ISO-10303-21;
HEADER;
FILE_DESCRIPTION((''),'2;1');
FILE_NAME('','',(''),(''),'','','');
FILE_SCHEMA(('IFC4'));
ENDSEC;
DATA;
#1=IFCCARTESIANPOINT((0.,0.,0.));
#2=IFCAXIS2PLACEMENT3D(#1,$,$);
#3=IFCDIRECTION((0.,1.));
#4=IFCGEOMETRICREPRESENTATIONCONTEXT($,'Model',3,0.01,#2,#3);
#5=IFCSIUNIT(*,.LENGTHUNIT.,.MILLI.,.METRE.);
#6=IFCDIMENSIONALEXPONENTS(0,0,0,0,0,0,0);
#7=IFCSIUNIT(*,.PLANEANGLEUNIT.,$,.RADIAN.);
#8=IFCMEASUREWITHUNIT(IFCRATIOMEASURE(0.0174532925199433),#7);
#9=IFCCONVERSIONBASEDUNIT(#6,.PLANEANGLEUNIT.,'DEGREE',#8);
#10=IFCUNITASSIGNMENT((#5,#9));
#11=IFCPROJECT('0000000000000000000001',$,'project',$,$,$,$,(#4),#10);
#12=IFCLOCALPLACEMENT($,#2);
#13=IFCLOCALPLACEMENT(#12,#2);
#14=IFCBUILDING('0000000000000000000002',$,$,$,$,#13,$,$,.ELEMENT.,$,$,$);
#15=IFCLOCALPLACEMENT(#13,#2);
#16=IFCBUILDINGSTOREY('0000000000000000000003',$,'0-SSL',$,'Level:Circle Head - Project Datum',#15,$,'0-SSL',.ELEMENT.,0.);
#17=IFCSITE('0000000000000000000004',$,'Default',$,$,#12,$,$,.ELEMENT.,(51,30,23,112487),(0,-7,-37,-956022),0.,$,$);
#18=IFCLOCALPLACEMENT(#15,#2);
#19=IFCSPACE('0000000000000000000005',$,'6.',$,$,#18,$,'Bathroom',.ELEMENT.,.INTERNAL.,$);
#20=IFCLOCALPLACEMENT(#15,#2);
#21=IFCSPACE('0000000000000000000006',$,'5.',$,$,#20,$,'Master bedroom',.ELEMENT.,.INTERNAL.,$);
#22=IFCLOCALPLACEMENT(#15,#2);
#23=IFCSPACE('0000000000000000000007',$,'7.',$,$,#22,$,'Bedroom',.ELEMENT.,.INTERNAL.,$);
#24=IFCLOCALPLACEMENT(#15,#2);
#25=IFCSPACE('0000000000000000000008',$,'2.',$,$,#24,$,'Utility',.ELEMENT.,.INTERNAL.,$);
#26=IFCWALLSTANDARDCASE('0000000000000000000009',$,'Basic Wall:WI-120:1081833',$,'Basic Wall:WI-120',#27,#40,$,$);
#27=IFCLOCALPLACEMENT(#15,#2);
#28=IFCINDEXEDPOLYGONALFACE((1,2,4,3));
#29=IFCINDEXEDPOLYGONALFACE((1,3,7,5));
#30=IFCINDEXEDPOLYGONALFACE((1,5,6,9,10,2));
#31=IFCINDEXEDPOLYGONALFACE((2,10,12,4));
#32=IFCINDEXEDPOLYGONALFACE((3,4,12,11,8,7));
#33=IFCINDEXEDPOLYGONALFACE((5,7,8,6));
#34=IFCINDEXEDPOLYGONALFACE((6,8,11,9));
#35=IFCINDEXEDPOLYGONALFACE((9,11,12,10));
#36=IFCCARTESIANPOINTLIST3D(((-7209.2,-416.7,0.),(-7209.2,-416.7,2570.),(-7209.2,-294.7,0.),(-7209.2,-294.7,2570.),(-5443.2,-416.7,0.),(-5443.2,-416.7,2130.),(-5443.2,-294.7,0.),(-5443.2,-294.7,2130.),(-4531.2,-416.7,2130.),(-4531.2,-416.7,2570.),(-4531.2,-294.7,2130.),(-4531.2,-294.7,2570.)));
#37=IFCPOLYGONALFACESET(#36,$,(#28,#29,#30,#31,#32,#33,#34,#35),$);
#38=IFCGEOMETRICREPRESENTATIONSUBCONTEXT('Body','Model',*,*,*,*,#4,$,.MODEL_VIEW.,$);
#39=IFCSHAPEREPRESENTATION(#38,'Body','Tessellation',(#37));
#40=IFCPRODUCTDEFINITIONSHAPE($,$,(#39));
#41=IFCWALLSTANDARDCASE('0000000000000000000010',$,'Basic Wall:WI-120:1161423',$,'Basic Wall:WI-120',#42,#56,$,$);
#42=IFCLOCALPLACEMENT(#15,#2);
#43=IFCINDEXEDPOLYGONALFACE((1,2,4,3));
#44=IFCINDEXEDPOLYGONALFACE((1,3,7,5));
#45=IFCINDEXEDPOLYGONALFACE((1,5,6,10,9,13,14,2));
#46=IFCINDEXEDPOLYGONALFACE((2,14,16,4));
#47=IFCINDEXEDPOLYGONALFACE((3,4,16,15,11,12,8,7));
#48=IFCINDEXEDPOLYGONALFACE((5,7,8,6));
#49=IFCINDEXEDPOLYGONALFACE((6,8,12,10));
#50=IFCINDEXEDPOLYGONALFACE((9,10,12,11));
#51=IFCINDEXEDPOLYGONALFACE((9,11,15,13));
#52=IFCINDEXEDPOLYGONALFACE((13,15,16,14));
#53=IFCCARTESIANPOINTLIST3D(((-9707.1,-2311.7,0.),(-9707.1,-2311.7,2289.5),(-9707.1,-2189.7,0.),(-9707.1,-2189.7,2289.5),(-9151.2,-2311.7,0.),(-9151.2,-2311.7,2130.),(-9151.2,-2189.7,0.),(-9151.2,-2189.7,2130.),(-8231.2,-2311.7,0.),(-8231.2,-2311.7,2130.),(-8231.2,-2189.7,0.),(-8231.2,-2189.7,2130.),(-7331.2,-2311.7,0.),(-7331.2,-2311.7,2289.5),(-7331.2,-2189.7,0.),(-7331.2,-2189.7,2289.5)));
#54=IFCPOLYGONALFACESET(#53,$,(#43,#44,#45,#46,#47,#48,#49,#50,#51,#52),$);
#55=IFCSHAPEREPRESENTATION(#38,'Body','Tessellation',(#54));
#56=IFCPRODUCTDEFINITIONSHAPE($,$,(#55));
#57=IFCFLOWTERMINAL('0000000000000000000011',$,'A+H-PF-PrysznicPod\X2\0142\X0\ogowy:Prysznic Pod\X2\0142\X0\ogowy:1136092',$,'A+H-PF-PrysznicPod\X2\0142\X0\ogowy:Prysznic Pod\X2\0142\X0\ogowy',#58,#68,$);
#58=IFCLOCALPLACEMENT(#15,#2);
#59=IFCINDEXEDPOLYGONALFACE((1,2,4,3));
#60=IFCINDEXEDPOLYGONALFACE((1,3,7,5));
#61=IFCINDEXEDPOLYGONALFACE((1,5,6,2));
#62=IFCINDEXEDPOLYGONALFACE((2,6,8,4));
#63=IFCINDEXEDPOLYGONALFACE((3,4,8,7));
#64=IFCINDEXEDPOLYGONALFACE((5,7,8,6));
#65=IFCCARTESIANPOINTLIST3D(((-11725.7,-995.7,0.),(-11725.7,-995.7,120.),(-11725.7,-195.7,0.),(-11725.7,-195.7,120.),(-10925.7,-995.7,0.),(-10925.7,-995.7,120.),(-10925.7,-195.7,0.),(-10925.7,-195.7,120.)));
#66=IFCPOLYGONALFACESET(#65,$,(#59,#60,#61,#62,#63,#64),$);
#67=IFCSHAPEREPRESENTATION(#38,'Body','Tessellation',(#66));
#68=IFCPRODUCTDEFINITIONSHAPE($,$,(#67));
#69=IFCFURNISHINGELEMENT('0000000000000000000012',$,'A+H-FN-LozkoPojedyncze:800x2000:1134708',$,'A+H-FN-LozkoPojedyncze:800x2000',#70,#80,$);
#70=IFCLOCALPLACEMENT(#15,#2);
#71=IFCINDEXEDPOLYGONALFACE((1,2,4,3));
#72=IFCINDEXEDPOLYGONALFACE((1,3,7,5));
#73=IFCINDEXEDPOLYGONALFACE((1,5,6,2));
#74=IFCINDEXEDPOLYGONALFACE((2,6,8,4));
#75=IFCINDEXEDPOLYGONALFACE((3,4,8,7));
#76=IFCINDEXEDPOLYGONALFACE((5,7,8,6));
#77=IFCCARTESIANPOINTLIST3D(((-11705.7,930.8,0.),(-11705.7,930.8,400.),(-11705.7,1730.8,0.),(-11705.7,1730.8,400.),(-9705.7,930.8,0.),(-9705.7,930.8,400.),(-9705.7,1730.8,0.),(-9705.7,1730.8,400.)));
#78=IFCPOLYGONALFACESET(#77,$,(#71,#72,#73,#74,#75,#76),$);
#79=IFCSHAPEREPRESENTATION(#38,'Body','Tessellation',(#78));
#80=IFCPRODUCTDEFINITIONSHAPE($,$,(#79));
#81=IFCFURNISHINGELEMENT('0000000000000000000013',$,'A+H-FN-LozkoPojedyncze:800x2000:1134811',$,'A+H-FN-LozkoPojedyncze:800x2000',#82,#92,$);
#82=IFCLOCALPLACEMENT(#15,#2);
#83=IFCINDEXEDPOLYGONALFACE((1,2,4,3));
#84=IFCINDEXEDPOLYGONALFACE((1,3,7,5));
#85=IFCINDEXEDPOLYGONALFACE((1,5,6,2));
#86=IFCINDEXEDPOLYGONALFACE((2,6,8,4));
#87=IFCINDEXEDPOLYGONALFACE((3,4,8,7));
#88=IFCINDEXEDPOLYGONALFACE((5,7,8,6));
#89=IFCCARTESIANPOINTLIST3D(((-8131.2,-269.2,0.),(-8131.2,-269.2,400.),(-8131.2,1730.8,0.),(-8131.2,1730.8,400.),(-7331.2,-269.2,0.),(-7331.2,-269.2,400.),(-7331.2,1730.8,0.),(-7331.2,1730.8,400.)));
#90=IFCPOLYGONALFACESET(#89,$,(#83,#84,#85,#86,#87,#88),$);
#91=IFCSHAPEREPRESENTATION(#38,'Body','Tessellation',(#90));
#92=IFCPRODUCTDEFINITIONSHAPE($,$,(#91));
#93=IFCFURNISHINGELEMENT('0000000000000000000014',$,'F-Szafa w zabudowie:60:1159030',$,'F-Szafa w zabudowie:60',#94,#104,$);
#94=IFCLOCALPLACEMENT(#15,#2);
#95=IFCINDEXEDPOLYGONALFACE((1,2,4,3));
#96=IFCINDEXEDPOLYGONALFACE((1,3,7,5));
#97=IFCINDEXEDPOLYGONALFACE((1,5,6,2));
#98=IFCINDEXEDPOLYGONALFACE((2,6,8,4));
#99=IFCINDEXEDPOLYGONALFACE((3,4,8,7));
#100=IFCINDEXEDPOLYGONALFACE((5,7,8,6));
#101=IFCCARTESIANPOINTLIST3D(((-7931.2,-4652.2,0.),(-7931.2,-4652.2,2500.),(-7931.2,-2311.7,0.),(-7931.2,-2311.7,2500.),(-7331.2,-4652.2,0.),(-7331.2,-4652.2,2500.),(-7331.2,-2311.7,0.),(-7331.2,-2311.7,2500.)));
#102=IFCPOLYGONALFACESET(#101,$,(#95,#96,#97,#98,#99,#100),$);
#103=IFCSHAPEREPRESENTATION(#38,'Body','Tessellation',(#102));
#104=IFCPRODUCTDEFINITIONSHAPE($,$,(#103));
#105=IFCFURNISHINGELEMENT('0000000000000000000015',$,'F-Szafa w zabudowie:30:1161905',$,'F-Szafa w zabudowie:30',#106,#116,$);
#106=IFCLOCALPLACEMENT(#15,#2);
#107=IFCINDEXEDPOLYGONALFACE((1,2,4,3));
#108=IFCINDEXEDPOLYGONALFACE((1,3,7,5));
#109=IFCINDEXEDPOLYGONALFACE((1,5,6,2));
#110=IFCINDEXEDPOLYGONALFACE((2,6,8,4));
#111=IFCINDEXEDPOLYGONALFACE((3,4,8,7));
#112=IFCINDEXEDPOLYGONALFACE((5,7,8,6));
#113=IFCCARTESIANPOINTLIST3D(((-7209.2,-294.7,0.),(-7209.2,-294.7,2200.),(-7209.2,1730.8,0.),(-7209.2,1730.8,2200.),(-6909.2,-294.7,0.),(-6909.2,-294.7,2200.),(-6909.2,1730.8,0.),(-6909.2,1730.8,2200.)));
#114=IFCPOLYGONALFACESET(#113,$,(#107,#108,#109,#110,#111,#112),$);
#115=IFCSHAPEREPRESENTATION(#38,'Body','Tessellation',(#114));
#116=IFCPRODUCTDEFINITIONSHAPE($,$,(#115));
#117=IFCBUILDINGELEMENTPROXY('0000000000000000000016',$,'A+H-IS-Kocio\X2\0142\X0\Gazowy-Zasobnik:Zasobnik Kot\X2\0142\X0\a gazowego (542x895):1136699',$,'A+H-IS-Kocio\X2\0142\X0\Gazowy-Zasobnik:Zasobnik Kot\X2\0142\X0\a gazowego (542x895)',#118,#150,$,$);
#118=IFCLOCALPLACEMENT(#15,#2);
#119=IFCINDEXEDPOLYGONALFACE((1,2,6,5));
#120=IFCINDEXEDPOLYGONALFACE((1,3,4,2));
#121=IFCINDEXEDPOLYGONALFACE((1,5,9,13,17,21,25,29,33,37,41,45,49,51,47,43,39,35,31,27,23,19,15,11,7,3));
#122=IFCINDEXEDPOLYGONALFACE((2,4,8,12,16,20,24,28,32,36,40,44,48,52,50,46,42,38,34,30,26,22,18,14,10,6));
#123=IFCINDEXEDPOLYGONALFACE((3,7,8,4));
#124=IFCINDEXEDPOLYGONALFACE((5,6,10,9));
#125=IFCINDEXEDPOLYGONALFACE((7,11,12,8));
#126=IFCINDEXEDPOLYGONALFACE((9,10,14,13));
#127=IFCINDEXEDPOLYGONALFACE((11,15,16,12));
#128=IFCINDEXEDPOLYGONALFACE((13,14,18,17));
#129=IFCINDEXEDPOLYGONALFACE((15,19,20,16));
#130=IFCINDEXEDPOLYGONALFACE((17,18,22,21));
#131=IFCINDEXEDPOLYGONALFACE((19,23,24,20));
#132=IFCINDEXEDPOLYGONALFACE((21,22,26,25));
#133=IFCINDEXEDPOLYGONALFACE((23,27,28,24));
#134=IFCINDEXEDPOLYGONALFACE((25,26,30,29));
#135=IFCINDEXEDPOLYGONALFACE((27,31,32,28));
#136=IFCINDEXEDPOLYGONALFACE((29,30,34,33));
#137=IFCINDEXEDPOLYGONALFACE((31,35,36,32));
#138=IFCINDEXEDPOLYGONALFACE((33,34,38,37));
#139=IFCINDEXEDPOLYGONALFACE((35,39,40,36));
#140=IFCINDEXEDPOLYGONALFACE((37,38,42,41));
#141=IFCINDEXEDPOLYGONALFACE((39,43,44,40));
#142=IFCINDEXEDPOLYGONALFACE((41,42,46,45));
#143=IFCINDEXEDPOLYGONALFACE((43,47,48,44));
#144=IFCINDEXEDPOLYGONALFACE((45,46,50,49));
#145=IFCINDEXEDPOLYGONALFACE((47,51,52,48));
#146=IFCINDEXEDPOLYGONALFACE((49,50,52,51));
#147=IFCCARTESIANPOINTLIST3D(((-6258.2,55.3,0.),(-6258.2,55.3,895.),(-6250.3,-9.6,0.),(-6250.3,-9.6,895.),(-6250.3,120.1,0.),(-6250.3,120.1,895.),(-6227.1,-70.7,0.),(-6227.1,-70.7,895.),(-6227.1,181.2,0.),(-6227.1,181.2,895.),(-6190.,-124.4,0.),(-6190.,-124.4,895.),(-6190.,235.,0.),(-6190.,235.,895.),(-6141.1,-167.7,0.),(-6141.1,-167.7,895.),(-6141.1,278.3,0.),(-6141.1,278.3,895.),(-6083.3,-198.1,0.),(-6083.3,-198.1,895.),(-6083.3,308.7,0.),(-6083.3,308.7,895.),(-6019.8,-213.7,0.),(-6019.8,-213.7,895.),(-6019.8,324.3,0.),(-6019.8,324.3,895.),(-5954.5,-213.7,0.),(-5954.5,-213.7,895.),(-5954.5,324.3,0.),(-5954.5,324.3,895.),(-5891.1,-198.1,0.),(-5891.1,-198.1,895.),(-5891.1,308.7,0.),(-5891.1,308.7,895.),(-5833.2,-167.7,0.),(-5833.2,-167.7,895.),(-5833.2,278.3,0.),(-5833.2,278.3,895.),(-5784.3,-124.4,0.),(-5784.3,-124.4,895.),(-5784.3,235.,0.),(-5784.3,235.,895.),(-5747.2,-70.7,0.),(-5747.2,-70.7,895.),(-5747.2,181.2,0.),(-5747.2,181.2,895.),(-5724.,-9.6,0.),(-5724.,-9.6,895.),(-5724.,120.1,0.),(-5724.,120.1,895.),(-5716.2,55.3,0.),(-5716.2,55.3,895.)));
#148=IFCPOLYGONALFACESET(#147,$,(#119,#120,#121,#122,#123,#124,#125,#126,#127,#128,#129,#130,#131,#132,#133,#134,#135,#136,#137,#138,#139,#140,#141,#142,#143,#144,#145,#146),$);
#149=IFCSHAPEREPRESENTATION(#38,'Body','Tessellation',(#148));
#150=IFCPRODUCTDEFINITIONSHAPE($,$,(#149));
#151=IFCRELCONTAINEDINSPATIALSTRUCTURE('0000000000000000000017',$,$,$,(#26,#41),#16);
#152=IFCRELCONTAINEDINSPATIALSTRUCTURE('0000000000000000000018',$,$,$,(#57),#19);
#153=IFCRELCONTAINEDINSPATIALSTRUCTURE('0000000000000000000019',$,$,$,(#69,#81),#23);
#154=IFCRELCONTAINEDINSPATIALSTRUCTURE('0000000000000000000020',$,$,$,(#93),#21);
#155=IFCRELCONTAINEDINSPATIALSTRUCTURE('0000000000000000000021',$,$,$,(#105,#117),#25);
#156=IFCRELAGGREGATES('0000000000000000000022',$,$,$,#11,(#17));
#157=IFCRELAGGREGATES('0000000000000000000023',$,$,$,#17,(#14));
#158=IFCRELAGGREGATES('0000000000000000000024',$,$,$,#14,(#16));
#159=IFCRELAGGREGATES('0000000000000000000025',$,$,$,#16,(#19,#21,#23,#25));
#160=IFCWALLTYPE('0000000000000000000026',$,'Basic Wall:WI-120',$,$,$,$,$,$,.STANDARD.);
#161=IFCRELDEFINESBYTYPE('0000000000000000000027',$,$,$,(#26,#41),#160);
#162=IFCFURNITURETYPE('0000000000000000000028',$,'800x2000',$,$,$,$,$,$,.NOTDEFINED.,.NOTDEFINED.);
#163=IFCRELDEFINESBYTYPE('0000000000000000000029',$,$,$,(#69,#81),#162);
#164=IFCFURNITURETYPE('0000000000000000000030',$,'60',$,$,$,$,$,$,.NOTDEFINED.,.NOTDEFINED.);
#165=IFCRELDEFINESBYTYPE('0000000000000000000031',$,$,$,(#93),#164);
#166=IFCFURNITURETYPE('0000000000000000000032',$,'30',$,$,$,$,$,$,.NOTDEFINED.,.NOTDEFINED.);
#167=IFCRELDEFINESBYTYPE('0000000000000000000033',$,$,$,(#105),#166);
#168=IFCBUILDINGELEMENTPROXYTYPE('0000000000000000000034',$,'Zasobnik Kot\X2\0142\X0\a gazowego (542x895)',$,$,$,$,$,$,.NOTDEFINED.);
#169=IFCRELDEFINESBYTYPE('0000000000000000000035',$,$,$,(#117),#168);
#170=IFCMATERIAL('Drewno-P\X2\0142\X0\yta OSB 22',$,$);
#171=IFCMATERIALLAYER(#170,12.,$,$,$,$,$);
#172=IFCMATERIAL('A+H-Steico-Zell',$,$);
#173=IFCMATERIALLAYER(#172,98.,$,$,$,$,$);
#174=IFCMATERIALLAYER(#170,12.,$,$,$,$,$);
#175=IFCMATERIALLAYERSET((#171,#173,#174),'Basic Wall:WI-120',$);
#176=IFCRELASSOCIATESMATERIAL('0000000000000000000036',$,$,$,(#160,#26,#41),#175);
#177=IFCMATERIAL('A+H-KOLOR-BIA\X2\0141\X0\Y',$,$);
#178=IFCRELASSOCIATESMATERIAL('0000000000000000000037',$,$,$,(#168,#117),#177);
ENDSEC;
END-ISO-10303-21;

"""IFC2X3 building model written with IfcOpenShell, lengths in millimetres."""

from ifc_helpers import new_model, entity, si_unit, converted_unit, direction, frame, frame_2d, origin, origin_2d_with_axis, place, context, subcontext, project, spatial, polyline, rectangle, circle, extrude, clip, bounded_halfspace, source, transform, mapped, material, layer, layer_set, layer_usage, type_object, type_shapes, element, save


model = new_model("IFC2X3")

# Units and contexts
model_context = context("Model", 3, precision=0.01, world=origin(), true_north=direction((0.0, 1.0)))
body_context = subcontext(model_context, "Body", "Model", "MODEL_VIEW")
ifc_project = project(units=[si_unit("LENGTHUNIT", "METRE", prefix="MILLI"), converted_unit("PLANEANGLEUNIT", "DEGREE", entity("IfcRatioMeasure", 0.0174532925199433), si_unit("PLANEANGLEUNIT", "RADIAN"), dimensions=[0, 0, 0, 0, 0, 0, 0])], contexts=[model_context])

# Site, building, storey
site_placement = place(None, origin())
site = spatial("IfcSite", under=ifc_project, at=site_placement, Name="Default", CompositionType="ELEMENT", RefLatitude=(51, 30, 23, 112487), RefLongitude=(0, -7, -37, -956022), RefElevation=0.0)
building_placement = place(site_placement, origin())
building = spatial("IfcBuilding", under=site, at=building_placement, CompositionType="ELEMENT")
storey_placement = place(building_placement, origin())
storey = spatial("IfcBuildingStorey", under=building, at=storey_placement, Name="0-SSL", ObjectType="Level:Circle Head - Project Datum", LongName="0-SSL", CompositionType="ELEMENT", Elevation=0.0)

# Shared definitions
ifc_material_1 = material(Name="A+H-Steico-Zell")

# Shared definitions
ifc_material_2 = material(Name="Drewno-Płyta OSB 22")

# Walls, openings
ifc_layer_1 = layer(ifc_material_2, 12.0)
ifc_layer_2 = layer(ifc_material_1, 98.0)
ifc_layer_3 = layer(ifc_material_2, 12.0)
ifc_layer_set_1 = layer_set([ifc_layer_1, ifc_layer_2, ifc_layer_3], Name="Basic Wall:WI-120")
wall_type_1 = type_object("IfcWallType", Name="Basic Wall:WI-120", PredefinedType="STANDARD", material=ifc_layer_set_1)
ifc_layer_usage_1 = layer_usage(ifc_layer_set_1, "AXIS2", "NEGATIVE", 61.0)
wall_1_placement = place(storey_placement, frame((-7209.2, -355.7, 0.0)))
wall_1 = element("IfcWallStandardCase", 1, at=wall_1_placement, inside=storey, type_object=wall_type_1, material=ifc_layer_usage_1, Name="Basic Wall:WI-120:1081833", ObjectType="Basic Wall:WI-120", context=body_context, shape_type="SweptSolid", body=[
    extrude(rectangle(XDim=2678.0, YDim=122.0, at=frame_2d((1339.0, 0.0), x_axis=(-1.0, 0.0))), origin(), (0.0, 0.0, 1.0), 2570.0),
])
opening_1_placement = place(wall_1_placement, frame((1766.0, -61.0, 0.0)))
element("IfcOpeningElement", 2, at=opening_1_placement, cuts=wall_1, ObjectType="Opening", context=body_context, shape_type="SweptSolid", body=[
    extrude(rectangle(XDim=2130.0, YDim=920.0, at=frame_2d((1065.0, 460.0), x_axis=(1.0, 0.0))), frame((0.0, 0.0, 0.0), z_axis=(0.0, 1.0, 0.0), x_axis=(0.0, 0.0, 1.0)), (0.0, 0.0, 1.0), 122.0),
])
ifc_layer_usage_2 = layer_usage(ifc_layer_set_1, "AXIS2", "NEGATIVE", 61.0)
wall_2_placement = place(storey_placement, frame((-9707.1, -2250.7, 0.0)))
wall_2 = element("IfcWallStandardCase", 3, at=wall_2_placement, inside=storey, type_object=wall_type_1, material=ifc_layer_usage_2, Name="Basic Wall:WI-120:1161423", ObjectType="Basic Wall:WI-120", context=body_context, shape_type="Clipping", body=[
    clip(extrude(rectangle(XDim=2375.9, YDim=122.0, at=frame_2d((1188.0, 0.0), x_axis=(-1.0, 0.0))), origin(), (0.0, 0.0, 1.0), 2289.5), bounded_halfspace(frame((0.0, 61.0, 2289.5), z_axis=(0.0, 0.0, -1.0), x_axis=(0.0, -1.0, 0.0)), True, frame((0.0, 61.0, 2289.5)), polyline([(0.0, 0.0), (0.0, -122.0), (2375.9, -122.0), (2375.9, 0.0), (520.9, 0.0), (0.0, 0.0)]))),
])
opening_2_placement = place(wall_2_placement, frame((1475.9, 61.0, 0.0)))
element("IfcOpeningElement", 4, at=opening_2_placement, cuts=wall_2, ObjectType="Opening", context=body_context, shape_type="SweptSolid", body=[
    extrude(rectangle(XDim=2130.0, YDim=920.0, at=frame_2d((1065.0, 460.0), x_axis=(1.0, 0.0))), frame((0.0, 0.0, 0.0), z_axis=(0.0, -1.0, 0.0), x_axis=(0.0, 0.0, 1.0)), (0.0, 0.0, 1.0), 122.0),
])

# Shared definitions
space_1_placement = place(storey_placement, origin())
space_1 = spatial("IfcSpace", under=storey, at=space_1_placement, Name="6.", LongName="Bathroom", CompositionType="ELEMENT", InteriorOrExteriorSpace="INTERNAL")

# Flow terminal
shared_shape_1 = source(origin(), body_context, "Body", "SweptSolid", [
    extrude(rectangle(XDim=800.0, YDim=800.0, at=origin_2d_with_axis()), frame((0.0, 400.0, 0.0), z_axis=(0.0, 0.0, 1.0), x_axis=(-1.0, 0.0, 0.0)), (0.0, 0.0, 1.0), 120.0),
])
flow_terminal_placement = place(space_1_placement, frame((-11325.7, -995.7, 0.0)))
element("IfcFlowTerminal", 5, at=flow_terminal_placement, inside=space_1, Name="A+H-PF-PrysznicPodłogowy:Prysznic Podłogowy:1136092", ObjectType="A+H-PF-PrysznicPodłogowy:Prysznic Podłogowy", context=body_context, shape_type="MappedRepresentation", body=[
    mapped(shared_shape_1, transform((0.0, 0.0, 0.0), scale=1.0)),
])

# Shared definitions
space_2_placement = place(storey_placement, origin())
space_2 = spatial("IfcSpace", under=storey, at=space_2_placement, Name="5.", LongName="Master bedroom", CompositionType="ELEMENT", InteriorOrExteriorSpace="INTERNAL")

# Shared definitions
space_3_placement = place(storey_placement, origin())
space_3 = spatial("IfcSpace", under=storey, at=space_3_placement, Name="7.", LongName="Bedroom", CompositionType="ELEMENT", InteriorOrExteriorSpace="INTERNAL")

# Furnishing elements
furniture_type_1 = type_object("IfcFurnitureType", Name="800x2000")
shared_shape_2 = source(origin(), body_context, "Body", "SweptSolid", [
    extrude(rectangle(XDim=800.0, YDim=2000.0, at=origin_2d_with_axis()), frame((0.0, 0.0, 0.0), z_axis=(0.0, 0.0, 1.0), x_axis=(-1.0, 0.0, 0.0)), (0.0, 0.0, 1.0), 400.0),
])
type_shapes(furniture_type_1, [shared_shape_2])
furnishing_1_placement = place(space_3_placement, frame((-10705.7, 1330.8, 0.0), z_axis=(0.0, 0.0, 1.0), x_axis=(0.0, 1.0, 0.0)))
element("IfcFurnishingElement", 6, at=furnishing_1_placement, inside=space_3, type_object=furniture_type_1, Name="A+H-FN-LozkoPojedyncze:800x2000:1134708", ObjectType="A+H-FN-LozkoPojedyncze:800x2000", context=body_context, shape_type="MappedRepresentation", body=[
    mapped(shared_shape_2, transform((0.0, 0.0, 0.0), scale=1.0)),
])
furnishing_2_placement = place(space_3_placement, frame((-7731.2, 730.8, 0.0)))
element("IfcFurnishingElement", 7, at=furnishing_2_placement, inside=space_3, type_object=furniture_type_1, Name="A+H-FN-LozkoPojedyncze:800x2000:1134811", ObjectType="A+H-FN-LozkoPojedyncze:800x2000", context=body_context, shape_type="MappedRepresentation", body=[
    mapped(shared_shape_2, transform((0.0, 0.0, 0.0), scale=1.0)),
])
furniture_type_2 = type_object("IfcFurnitureType", Name="60")
shared_shape_3 = source(origin(), body_context, "Body", "SweptSolid", [
    extrude(rectangle(XDim=600.0, YDim=2340.5, at=origin_2d_with_axis()), frame((0.0, 0.0, 0.0), z_axis=(0.0, 0.0, 1.0), x_axis=(-1.0, 0.0, 0.0)), (0.0, 0.0, 1.0), 2500.0),
])
type_shapes(furniture_type_2, [shared_shape_3])
furnishing_3_placement = place(space_2_placement, frame((-7631.2, -3482.0, 0.0)))
element("IfcFurnishingElement", 8, at=furnishing_3_placement, inside=space_2, type_object=furniture_type_2, Name="F-Szafa w zabudowie:60:1159030", ObjectType="F-Szafa w zabudowie:60", context=body_context, shape_type="MappedRepresentation", body=[
    mapped(shared_shape_3, transform((0.0, 0.0, 0.0), scale=1.0)),
])

# Shared definitions
space_4_placement = place(storey_placement, origin())
space_4 = spatial("IfcSpace", under=storey, at=space_4_placement, Name="2.", LongName="Utility", CompositionType="ELEMENT", InteriorOrExteriorSpace="INTERNAL")

# Furnishing element
furniture_type_3 = type_object("IfcFurnitureType", Name="30")
shared_shape_4 = source(origin(), body_context, "Body", "SweptSolid", [
    extrude(rectangle(XDim=300.0, YDim=2025.5, at=frame_2d((0.0, 0.0), x_axis=(1.0, 0.0))), frame((0.0, 0.0, 0.0), z_axis=(0.0, 0.0, 1.0), x_axis=(-1.0, 0.0, 0.0)), (0.0, 0.0, 1.0), 2200.0),
])
type_shapes(furniture_type_3, [shared_shape_4])
furnishing_4_placement = place(space_4_placement, frame((-7059.2, 718.0, 0.0)))
element("IfcFurnishingElement", 9, at=furnishing_4_placement, inside=space_4, type_object=furniture_type_3, Name="F-Szafa w zabudowie:30:1161905", ObjectType="F-Szafa w zabudowie:30", context=body_context, shape_type="MappedRepresentation", body=[
    mapped(shared_shape_4, transform((0.0, 0.0, 0.0), scale=1.0)),
])

# Building element proxy
ifc_material_3 = material(Name="A+H-KOLOR-BIAŁY")
building_element_proxy_type = type_object("IfcBuildingElementProxyType", Name="Zasobnik Kotła gazowego (542x895)", PredefinedType="NOTDEFINED", material=ifc_material_3)
shared_shape_5 = source(origin(), body_context, "Body", "SweptSolid", [
    extrude(circle(Radius=271.0, at=frame_2d((0.0, 0.0), x_axis=(1.0, 0.0))), origin(), (0.0, 0.0, 1.0), 895.0),
])
type_shapes(building_element_proxy_type, [shared_shape_5])
proxy_placement = place(space_4_placement, frame((-5987.2, 55.3, 0.0)))
element("IfcBuildingElementProxy", 10, at=proxy_placement, inside=space_4, type_object=building_element_proxy_type, material=ifc_material_3, Name="A+H-IS-KociołGazowy-Zasobnik:Zasobnik Kotła gazowego (542x895):1136699", ObjectType="A+H-IS-KociołGazowy-Zasobnik:Zasobnik Kotła gazowego (542x895)", context=body_context, shape_type="MappedRepresentation", body=[
    mapped(shared_shape_5, transform((0.0, 0.0, 0.0), scale=1.0)),
])

save(model, "model.ifc")
